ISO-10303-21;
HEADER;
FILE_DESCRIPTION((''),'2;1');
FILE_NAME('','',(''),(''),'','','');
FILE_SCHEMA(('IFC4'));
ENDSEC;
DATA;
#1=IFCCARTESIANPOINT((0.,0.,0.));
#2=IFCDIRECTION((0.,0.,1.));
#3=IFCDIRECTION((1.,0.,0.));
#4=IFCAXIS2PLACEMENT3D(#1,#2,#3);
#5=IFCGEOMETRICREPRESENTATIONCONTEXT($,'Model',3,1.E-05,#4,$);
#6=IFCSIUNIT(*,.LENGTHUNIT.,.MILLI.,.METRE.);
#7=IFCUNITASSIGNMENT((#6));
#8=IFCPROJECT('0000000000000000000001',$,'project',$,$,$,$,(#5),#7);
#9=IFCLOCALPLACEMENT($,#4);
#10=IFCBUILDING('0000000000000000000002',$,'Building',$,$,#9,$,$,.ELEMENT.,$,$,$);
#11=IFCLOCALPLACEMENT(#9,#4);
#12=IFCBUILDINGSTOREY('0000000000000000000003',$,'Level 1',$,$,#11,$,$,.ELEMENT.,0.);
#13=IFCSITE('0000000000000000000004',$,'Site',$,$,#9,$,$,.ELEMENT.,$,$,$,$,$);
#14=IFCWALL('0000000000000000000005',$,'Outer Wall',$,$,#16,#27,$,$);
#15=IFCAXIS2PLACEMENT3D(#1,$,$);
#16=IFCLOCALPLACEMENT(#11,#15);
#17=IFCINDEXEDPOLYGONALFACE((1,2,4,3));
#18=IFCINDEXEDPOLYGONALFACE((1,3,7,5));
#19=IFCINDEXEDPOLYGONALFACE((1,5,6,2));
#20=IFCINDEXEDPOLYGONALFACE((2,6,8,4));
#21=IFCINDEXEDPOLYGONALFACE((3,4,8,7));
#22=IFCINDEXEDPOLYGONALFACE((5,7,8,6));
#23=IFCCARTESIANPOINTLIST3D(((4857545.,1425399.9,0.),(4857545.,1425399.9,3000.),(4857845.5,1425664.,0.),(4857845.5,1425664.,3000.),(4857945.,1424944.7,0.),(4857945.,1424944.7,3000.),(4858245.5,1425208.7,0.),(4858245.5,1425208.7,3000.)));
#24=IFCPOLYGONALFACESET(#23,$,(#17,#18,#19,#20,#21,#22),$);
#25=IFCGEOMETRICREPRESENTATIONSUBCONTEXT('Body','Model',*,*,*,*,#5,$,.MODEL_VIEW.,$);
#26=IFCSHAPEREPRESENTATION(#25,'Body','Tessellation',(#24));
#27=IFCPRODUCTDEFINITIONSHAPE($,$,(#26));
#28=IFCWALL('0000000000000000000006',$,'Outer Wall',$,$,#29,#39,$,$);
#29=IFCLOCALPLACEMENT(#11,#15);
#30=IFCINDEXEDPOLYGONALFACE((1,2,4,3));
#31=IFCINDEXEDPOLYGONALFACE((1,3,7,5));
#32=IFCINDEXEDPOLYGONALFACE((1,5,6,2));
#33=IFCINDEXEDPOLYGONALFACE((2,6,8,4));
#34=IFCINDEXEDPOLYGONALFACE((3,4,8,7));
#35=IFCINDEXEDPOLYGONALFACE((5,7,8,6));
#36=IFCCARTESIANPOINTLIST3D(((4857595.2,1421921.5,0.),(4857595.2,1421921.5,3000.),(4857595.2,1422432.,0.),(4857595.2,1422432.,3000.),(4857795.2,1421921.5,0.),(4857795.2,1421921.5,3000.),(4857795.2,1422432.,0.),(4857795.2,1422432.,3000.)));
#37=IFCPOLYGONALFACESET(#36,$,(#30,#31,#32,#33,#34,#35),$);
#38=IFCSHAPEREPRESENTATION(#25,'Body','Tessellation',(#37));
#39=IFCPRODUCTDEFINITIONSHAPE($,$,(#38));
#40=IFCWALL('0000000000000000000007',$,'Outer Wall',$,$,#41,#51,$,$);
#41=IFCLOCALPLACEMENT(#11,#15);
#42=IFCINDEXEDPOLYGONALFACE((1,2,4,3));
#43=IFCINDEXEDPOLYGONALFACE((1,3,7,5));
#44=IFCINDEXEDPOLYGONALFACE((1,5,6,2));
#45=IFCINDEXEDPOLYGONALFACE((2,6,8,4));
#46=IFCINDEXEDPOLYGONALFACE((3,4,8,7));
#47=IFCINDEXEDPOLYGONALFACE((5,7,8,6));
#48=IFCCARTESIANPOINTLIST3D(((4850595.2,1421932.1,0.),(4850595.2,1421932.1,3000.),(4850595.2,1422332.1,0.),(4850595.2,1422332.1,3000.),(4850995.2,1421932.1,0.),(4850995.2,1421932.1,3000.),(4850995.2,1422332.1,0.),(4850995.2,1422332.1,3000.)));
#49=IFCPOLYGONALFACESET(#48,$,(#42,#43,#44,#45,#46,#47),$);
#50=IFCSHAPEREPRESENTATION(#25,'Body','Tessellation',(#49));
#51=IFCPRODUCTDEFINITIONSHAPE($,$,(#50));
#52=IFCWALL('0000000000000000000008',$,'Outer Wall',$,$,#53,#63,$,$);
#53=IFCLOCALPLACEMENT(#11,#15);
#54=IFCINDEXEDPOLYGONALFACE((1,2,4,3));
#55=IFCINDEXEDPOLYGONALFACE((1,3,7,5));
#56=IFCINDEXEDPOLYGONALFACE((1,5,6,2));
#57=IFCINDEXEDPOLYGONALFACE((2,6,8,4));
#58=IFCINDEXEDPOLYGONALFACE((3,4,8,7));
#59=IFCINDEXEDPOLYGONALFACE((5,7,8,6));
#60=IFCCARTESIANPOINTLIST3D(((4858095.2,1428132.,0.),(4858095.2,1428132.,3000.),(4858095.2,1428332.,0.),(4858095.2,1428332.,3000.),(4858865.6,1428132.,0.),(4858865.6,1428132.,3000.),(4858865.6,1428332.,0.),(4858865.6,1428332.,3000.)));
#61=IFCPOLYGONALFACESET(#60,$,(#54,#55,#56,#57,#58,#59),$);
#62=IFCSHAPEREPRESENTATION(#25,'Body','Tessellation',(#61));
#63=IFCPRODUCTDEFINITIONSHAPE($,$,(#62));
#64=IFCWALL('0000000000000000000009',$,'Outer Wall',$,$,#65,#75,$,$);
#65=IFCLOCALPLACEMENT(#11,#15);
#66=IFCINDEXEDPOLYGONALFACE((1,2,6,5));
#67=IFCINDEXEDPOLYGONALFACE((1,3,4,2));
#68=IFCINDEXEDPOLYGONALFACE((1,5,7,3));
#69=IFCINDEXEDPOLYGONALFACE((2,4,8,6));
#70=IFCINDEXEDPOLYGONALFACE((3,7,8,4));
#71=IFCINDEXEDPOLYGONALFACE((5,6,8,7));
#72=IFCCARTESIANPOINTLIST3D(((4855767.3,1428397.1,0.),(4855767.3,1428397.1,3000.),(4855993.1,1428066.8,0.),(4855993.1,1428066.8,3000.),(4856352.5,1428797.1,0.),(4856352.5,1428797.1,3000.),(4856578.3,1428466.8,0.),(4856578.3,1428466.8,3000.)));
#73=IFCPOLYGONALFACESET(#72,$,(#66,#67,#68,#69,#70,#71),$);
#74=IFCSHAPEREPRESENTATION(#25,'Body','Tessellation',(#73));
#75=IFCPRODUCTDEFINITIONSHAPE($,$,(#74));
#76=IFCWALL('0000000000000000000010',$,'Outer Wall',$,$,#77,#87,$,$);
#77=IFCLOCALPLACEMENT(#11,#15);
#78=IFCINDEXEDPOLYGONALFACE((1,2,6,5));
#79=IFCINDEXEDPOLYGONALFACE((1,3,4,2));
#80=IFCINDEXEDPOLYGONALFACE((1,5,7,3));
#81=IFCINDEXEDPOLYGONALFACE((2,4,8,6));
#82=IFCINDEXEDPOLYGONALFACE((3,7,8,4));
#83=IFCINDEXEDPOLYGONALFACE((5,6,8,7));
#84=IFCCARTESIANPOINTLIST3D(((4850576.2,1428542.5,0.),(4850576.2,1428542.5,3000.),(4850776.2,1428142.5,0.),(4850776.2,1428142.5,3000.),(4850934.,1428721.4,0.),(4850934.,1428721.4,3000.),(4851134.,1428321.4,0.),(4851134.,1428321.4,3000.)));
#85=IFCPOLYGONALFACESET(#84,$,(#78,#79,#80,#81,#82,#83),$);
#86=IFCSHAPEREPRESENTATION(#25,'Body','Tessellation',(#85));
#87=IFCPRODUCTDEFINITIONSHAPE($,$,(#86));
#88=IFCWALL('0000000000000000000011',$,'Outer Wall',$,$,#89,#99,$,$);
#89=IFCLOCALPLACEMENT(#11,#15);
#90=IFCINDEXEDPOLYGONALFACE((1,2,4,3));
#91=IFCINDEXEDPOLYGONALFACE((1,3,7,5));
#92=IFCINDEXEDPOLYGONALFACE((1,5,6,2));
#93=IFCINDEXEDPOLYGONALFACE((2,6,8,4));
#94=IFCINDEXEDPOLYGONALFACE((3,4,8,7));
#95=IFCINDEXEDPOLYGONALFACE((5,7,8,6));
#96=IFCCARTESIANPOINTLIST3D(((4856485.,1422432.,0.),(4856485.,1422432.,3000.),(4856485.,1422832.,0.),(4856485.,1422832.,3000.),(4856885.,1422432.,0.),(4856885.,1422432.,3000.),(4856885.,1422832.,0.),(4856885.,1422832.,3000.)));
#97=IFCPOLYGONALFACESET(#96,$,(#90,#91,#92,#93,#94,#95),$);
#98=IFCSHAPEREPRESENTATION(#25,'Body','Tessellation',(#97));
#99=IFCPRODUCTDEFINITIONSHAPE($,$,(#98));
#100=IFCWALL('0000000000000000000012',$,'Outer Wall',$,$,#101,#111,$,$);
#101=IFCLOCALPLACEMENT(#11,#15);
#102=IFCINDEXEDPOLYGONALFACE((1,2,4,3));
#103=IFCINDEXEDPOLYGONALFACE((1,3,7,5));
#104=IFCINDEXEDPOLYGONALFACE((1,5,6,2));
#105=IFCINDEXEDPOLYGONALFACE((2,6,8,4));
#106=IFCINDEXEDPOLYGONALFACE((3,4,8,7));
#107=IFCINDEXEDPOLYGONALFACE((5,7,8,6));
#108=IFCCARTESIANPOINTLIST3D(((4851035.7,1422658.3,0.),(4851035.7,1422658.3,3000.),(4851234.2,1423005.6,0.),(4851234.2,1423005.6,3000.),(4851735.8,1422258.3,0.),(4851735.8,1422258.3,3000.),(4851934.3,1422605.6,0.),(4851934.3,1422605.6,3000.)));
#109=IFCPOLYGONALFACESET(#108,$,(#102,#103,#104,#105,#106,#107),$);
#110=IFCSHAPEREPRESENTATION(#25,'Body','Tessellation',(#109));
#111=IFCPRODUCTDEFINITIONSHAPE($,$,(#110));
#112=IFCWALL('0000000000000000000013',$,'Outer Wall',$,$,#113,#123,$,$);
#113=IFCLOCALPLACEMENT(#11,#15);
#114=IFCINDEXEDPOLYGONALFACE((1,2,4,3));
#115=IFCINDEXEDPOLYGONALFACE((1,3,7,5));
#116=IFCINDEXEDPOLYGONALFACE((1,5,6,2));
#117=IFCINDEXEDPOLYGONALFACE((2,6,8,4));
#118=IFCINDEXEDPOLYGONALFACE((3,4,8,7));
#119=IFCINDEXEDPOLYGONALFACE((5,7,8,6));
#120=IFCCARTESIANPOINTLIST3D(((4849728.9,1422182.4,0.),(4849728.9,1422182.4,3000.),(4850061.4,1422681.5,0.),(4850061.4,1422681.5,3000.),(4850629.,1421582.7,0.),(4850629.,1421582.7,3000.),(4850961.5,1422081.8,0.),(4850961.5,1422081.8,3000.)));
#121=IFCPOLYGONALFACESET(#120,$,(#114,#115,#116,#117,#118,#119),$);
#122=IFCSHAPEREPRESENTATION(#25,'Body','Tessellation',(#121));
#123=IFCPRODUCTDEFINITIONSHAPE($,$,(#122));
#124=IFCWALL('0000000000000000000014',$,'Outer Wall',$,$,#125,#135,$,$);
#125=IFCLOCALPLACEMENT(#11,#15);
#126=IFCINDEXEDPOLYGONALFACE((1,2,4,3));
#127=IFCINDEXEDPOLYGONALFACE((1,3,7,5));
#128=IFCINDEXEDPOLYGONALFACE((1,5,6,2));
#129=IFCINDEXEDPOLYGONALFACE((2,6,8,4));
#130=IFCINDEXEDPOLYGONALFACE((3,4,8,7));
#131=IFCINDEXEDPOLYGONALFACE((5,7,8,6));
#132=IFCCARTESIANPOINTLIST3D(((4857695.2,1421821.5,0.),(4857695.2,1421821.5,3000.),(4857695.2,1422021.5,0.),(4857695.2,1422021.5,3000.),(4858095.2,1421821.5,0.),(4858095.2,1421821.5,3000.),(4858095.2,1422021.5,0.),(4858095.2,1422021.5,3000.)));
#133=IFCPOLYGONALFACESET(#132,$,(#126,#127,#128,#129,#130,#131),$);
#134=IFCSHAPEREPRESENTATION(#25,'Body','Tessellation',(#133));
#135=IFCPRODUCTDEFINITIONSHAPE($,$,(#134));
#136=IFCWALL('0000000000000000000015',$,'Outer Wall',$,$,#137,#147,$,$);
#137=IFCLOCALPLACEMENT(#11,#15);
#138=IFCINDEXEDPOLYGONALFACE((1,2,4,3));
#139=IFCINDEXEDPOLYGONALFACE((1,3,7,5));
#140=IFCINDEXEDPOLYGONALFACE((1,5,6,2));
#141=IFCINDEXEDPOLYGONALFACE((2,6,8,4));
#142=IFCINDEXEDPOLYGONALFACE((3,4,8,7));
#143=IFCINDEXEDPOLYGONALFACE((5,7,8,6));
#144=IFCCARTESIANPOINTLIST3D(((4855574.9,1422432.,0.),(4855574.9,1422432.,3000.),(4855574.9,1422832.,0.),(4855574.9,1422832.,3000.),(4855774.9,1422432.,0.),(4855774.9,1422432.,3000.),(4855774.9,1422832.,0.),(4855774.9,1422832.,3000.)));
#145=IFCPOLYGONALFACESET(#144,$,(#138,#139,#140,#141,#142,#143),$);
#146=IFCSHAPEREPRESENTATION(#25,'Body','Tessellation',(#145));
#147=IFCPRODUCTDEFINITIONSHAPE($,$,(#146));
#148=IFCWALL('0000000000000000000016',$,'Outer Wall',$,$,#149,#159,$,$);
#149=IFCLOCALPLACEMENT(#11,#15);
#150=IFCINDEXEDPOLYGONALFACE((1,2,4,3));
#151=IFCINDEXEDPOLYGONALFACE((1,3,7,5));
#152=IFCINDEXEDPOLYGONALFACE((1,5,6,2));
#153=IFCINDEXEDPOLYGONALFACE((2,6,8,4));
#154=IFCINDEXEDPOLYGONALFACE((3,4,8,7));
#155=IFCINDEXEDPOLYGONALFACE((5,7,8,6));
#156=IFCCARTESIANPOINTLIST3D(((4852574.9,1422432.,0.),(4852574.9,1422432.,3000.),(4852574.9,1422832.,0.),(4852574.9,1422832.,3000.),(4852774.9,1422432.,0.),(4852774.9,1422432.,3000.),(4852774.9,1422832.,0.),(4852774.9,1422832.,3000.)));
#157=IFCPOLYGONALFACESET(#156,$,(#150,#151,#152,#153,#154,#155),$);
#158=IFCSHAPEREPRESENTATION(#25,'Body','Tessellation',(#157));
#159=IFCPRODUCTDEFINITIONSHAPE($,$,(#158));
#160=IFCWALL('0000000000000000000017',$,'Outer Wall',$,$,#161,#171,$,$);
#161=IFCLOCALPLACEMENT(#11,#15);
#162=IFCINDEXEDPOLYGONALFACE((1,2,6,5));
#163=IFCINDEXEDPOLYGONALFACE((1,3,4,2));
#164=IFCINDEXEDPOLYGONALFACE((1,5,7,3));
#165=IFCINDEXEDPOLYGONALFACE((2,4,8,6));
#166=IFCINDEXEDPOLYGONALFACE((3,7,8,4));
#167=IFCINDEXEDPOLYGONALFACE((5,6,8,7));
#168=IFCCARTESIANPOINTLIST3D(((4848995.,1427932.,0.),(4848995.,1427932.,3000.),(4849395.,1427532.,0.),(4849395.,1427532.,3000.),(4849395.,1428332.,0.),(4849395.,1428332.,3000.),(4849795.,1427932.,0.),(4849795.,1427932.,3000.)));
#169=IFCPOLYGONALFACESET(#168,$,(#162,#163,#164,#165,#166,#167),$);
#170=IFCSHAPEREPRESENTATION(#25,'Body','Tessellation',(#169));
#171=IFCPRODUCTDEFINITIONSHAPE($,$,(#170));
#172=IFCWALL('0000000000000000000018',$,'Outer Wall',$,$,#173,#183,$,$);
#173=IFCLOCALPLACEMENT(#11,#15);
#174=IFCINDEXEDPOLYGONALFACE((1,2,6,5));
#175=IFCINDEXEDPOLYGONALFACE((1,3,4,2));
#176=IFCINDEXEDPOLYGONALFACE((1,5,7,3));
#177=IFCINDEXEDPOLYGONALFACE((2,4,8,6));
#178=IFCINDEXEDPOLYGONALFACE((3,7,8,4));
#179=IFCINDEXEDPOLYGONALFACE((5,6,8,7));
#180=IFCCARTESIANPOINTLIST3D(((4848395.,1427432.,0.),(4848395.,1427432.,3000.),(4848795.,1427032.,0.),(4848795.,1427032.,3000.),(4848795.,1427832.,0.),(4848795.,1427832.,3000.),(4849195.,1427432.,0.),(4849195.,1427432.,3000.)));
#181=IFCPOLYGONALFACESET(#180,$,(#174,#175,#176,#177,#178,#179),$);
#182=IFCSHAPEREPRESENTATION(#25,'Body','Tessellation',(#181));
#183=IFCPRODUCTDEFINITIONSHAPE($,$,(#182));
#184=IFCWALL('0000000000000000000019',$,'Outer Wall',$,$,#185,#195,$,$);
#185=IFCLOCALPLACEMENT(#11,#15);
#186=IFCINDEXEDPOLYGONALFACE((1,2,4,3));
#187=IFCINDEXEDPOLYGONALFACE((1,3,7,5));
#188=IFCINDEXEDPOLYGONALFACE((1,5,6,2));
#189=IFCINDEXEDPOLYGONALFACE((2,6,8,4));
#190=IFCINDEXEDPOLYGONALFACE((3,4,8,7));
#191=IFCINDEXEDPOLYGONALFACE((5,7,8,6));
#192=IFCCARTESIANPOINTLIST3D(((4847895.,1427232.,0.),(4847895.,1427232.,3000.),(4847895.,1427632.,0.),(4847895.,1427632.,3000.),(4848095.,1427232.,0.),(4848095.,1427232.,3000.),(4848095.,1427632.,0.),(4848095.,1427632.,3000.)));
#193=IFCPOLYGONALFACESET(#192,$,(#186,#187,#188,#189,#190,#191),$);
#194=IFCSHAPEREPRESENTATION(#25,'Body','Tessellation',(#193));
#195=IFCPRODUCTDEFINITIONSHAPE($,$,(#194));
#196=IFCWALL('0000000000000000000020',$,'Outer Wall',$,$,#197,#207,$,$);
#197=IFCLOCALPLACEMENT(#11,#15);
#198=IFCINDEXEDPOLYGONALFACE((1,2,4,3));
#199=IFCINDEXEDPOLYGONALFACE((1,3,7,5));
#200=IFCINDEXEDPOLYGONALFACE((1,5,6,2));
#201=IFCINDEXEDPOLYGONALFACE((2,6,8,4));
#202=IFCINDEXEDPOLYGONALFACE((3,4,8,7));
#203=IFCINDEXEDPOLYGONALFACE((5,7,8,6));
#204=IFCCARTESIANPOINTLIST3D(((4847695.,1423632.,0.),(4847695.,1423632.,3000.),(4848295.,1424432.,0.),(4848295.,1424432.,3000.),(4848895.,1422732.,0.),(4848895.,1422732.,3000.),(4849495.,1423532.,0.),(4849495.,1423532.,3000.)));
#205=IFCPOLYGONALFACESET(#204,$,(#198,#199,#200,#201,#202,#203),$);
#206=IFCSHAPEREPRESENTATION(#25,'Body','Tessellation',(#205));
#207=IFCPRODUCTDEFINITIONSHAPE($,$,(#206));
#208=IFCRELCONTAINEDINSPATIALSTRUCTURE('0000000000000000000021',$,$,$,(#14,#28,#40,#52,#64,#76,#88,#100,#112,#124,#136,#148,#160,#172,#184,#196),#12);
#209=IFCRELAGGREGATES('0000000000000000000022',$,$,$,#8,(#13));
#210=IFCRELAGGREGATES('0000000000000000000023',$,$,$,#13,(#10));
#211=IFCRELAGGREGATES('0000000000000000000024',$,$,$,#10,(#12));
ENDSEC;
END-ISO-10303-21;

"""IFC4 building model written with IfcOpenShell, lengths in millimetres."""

from ifc_helpers import new_model, si_unit, frame, frame_2d, origin_with_axes, place, context, subcontext, project, spatial, rectangle, extrude, element, save


model = new_model("IFC4")

# Units and contexts
model_context = context("Model", 3, precision=1e-05, world=origin_with_axes())
body_context = subcontext(model_context, "Body", "Model", "MODEL_VIEW")
ifc_project = project(units=[si_unit("LENGTHUNIT", "METRE", prefix="MILLI")], contexts=[model_context])

# Site, building, storey
placement = place(None, origin_with_axes())
site = spatial("IfcSite", under=ifc_project, at=placement, Name="Site", CompositionType="ELEMENT")
building = spatial("IfcBuilding", under=site, at=placement, Name="Building", CompositionType="ELEMENT")
storey_placement = place(placement, origin_with_axes())
storey = spatial("IfcBuildingStorey", under=building, at=storey_placement, Name="Level 1", CompositionType="ELEMENT", Elevation=0.0)

# Walls
wall_1_placement = place(placement, frame((4857695.2, 1425532.0, 0.0), z_axis=(0.0, 0.0, 1.0), x_axis=(0.660054, -0.751218, 0.0)))
element("IfcWall", 1, at=wall_1_placement, inside=storey, Name="Outer Wall", context=body_context, shape_type="SweptSolid", body=[
    extrude(rectangle(XDim=606.0, YDim=400.0, at=frame_2d((303.0, 0.0), x_axis=(1.0, 0.0))), origin_with_axes(), (0.0, 0.0, 1.0), 3000.0),
])
wall_2_placement = place(placement, frame((4857695.2, 1422432.0, 0.0), z_axis=(0.0, 0.0, 1.0), x_axis=(0.0, -1.0, 0.0)))
element("IfcWall", 2, at=wall_2_placement, inside=storey, Name="Outer Wall", context=body_context, shape_type="SweptSolid", body=[
    extrude(rectangle(XDim=510.5, YDim=200.0, at=frame_2d((255.2, 0.0), x_axis=(1.0, 0.0))), origin_with_axes(), (0.0, 0.0, 1.0), 3000.0),
])
wall_3_placement = place(placement, frame((4850995.2, 1422132.1, 0.0), z_axis=(0.0, 0.0, 1.0), x_axis=(-1.0, 0.0, 0.0)))
element("IfcWall", 3, at=wall_3_placement, inside=storey, Name="Outer Wall", context=body_context, shape_type="SweptSolid", body=[
    extrude(rectangle(XDim=400.0, YDim=400.0, at=frame_2d((200.0, 0.0), x_axis=(1.0, 0.0))), origin_with_axes(), (0.0, 0.0, 1.0), 3000.0),
])
wall_4_placement = place(placement, frame((4858865.6, 1428232.0, 0.0), z_axis=(0.0, 0.0, 1.0), x_axis=(-1.0, 0.0, 0.0)))
element("IfcWall", 4, at=wall_4_placement, inside=storey, Name="Outer Wall", context=body_context, shape_type="SweptSolid", body=[
    extrude(rectangle(XDim=770.4, YDim=200.0, at=frame_2d((385.2, 0.0), x_axis=(1.0, 0.0))), origin_with_axes(), (0.0, 0.0, 1.0), 3000.0),
])
wall_5_placement = place(placement, frame((4855880.2, 1428232.0, 0.0), z_axis=(0.0, 0.0, 1.0), x_axis=(0.82557, 0.5643, 0.0)))
element("IfcWall", 5, at=wall_5_placement, inside=storey, Name="Outer Wall", context=body_context, shape_type="SweptSolid", body=[
    extrude(rectangle(XDim=708.8, YDim=400.0, at=frame_2d((354.4, 0.0), x_axis=(1.0, 0.0))), origin_with_axes(), (0.0, 0.0, 1.0), 3000.0),
])
wall_6_placement = place(placement, frame((4850955.1, 1428232.0, 0.0), z_axis=(0.0, 0.0, 1.0), x_axis=(-0.447214, 0.894427, 0.0)))
element("IfcWall", 6, at=wall_6_placement, inside=storey, Name="Outer Wall", context=body_context, shape_type="SweptSolid", body=[
    extrude(rectangle(XDim=447.2, YDim=400.0, at=frame_2d((223.6, 0.0), x_axis=(1.0, 0.0))), origin_with_axes(), (0.0, 0.0, 1.0), 3000.0),
])
wall_7_placement = place(placement, frame((4856685.0, 1422432.0, 0.0), z_axis=(0.0, 0.0, 1.0), x_axis=(0.0, 1.0, 0.0)))
element("IfcWall", 7, at=wall_7_placement, inside=storey, Name="Outer Wall", context=body_context, shape_type="SweptSolid", body=[
    extrude(rectangle(XDim=400.0, YDim=400.0, at=frame_2d((200.0, 0.0), x_axis=(1.0, 0.0))), origin_with_axes(), (0.0, 0.0, 1.0), 3000.0),
])
wall_8_placement = place(placement, frame((4851835.0, 1422432.0, 0.0), z_axis=(0.0, 0.0, 1.0), x_axis=(-0.868273, 0.496087, 0.0)))
element("IfcWall", 8, at=wall_8_placement, inside=storey, Name="Outer Wall", context=body_context, shape_type="SweptSolid", body=[
    extrude(rectangle(XDim=806.3, YDim=400.0, at=frame_2d((403.2, 0.0), x_axis=(1.0, 0.0))), origin_with_axes(), (0.0, 0.0, 1.0), 3000.0),
])
wall_9_placement = place(placement, frame((4849895.1, 1422432.0, 0.0), z_axis=(0.0, 0.0, 1.0), x_axis=(0.832205, -0.554468, 0.0)))
element("IfcWall", 9, at=wall_9_placement, inside=storey, Name="Outer Wall", context=body_context, shape_type="SweptSolid", body=[
    extrude(rectangle(XDim=1081.6, YDim=599.7, at=frame_2d((540.8, 0.0), x_axis=(1.0, 0.0))), origin_with_axes(), (0.0, 0.0, 1.0), 3000.0),
])
wall_10_placement = place(placement, frame((4857695.2, 1421921.5, 0.0), z_axis=(0.0, 0.0, 1.0), x_axis=(1.0, 0.0, 0.0)))
element("IfcWall", 10, at=wall_10_placement, inside=storey, Name="Outer Wall", context=body_context, shape_type="SweptSolid", body=[
    extrude(rectangle(XDim=400.0, YDim=200.0, at=frame_2d((200.0, 0.0), x_axis=(1.0, 0.0))), origin_with_axes(), (0.0, 0.0, 1.0), 3000.0),
])
for number, where, z_axis, x_axis, name in (
    (11, (4855674.9, 1422432.0, 0.0), (0.0, 0.0, 1.0), (0.0, 1.0, 0.0), "Outer Wall"),
    (12, (4852674.9, 1422432.0, 0.0), (0.0, 0.0, 1.0), (0.0, 1.0, 0.0), "Outer Wall"),
):
    element("IfcWall", number, at=place(placement, frame(where, z_axis=z_axis, x_axis=x_axis)), inside=storey, Name=name, context=body_context, shape_type="SweptSolid", body=[
        extrude(rectangle(XDim=400.0, YDim=200.0, at=frame_2d((200.0, 0.0), x_axis=(1.0, 0.0))), origin_with_axes(), (0.0, 0.0, 1.0), 3000.0),
    ])
wall_11_placement = place(placement, frame((4849195.0, 1428132.0, 0.0), z_axis=(0.0, 0.0, 1.0), x_axis=(0.707107, -0.707107, 0.0)))
element("IfcWall", 13, at=wall_11_placement, inside=storey, Name="Outer Wall", context=body_context, shape_type="SweptSolid", body=[
    extrude(rectangle(XDim=565.7, YDim=565.7, at=frame_2d((282.8, 0.0), x_axis=(1.0, 0.0))), origin_with_axes(), (0.0, 0.0, 1.0), 3000.0),
])
wall_12_placement = place(placement, frame((4848995.0, 1427232.0, 0.0), z_axis=(0.0, 0.0, 1.0), x_axis=(-0.707107, 0.707107, 0.0)))
element("IfcWall", 14, at=wall_12_placement, inside=storey, Name="Outer Wall", context=body_context, shape_type="SweptSolid", body=[
    extrude(rectangle(XDim=565.7, YDim=565.7, at=frame_2d((282.8, 0.0), x_axis=(1.0, 0.0))), origin_with_axes(), (0.0, 0.0, 1.0), 3000.0),
])
wall_13_placement = place(placement, frame((4847995.0, 1427632.0, 0.0), z_axis=(0.0, 0.0, 1.0), x_axis=(0.0, -1.0, 0.0)))
element("IfcWall", 15, at=wall_13_placement, inside=storey, Name="Outer Wall", context=body_context, shape_type="SweptSolid", body=[
    extrude(rectangle(XDim=400.0, YDim=200.0, at=frame_2d((200.0, 0.0), x_axis=(1.0, 0.0))), origin_with_axes(), (0.0, 0.0, 1.0), 3000.0),
])
wall_14_placement = place(placement, frame((4847995.0, 1424032.0, 0.0), z_axis=(0.0, 0.0, 1.0), x_axis=(0.8, -0.6, 0.0)))
element("IfcWall", 16, at=wall_14_placement, inside=storey, Name="Outer Wall", context=body_context, shape_type="SweptSolid", body=[
    extrude(rectangle(XDim=1500.0, YDim=1000.0, at=frame_2d((750.0, 0.0), x_axis=(1.0, 0.0))), origin_with_axes(), (0.0, 0.0, 1.0), 3000.0),
])

save(model, "model.ifc")
